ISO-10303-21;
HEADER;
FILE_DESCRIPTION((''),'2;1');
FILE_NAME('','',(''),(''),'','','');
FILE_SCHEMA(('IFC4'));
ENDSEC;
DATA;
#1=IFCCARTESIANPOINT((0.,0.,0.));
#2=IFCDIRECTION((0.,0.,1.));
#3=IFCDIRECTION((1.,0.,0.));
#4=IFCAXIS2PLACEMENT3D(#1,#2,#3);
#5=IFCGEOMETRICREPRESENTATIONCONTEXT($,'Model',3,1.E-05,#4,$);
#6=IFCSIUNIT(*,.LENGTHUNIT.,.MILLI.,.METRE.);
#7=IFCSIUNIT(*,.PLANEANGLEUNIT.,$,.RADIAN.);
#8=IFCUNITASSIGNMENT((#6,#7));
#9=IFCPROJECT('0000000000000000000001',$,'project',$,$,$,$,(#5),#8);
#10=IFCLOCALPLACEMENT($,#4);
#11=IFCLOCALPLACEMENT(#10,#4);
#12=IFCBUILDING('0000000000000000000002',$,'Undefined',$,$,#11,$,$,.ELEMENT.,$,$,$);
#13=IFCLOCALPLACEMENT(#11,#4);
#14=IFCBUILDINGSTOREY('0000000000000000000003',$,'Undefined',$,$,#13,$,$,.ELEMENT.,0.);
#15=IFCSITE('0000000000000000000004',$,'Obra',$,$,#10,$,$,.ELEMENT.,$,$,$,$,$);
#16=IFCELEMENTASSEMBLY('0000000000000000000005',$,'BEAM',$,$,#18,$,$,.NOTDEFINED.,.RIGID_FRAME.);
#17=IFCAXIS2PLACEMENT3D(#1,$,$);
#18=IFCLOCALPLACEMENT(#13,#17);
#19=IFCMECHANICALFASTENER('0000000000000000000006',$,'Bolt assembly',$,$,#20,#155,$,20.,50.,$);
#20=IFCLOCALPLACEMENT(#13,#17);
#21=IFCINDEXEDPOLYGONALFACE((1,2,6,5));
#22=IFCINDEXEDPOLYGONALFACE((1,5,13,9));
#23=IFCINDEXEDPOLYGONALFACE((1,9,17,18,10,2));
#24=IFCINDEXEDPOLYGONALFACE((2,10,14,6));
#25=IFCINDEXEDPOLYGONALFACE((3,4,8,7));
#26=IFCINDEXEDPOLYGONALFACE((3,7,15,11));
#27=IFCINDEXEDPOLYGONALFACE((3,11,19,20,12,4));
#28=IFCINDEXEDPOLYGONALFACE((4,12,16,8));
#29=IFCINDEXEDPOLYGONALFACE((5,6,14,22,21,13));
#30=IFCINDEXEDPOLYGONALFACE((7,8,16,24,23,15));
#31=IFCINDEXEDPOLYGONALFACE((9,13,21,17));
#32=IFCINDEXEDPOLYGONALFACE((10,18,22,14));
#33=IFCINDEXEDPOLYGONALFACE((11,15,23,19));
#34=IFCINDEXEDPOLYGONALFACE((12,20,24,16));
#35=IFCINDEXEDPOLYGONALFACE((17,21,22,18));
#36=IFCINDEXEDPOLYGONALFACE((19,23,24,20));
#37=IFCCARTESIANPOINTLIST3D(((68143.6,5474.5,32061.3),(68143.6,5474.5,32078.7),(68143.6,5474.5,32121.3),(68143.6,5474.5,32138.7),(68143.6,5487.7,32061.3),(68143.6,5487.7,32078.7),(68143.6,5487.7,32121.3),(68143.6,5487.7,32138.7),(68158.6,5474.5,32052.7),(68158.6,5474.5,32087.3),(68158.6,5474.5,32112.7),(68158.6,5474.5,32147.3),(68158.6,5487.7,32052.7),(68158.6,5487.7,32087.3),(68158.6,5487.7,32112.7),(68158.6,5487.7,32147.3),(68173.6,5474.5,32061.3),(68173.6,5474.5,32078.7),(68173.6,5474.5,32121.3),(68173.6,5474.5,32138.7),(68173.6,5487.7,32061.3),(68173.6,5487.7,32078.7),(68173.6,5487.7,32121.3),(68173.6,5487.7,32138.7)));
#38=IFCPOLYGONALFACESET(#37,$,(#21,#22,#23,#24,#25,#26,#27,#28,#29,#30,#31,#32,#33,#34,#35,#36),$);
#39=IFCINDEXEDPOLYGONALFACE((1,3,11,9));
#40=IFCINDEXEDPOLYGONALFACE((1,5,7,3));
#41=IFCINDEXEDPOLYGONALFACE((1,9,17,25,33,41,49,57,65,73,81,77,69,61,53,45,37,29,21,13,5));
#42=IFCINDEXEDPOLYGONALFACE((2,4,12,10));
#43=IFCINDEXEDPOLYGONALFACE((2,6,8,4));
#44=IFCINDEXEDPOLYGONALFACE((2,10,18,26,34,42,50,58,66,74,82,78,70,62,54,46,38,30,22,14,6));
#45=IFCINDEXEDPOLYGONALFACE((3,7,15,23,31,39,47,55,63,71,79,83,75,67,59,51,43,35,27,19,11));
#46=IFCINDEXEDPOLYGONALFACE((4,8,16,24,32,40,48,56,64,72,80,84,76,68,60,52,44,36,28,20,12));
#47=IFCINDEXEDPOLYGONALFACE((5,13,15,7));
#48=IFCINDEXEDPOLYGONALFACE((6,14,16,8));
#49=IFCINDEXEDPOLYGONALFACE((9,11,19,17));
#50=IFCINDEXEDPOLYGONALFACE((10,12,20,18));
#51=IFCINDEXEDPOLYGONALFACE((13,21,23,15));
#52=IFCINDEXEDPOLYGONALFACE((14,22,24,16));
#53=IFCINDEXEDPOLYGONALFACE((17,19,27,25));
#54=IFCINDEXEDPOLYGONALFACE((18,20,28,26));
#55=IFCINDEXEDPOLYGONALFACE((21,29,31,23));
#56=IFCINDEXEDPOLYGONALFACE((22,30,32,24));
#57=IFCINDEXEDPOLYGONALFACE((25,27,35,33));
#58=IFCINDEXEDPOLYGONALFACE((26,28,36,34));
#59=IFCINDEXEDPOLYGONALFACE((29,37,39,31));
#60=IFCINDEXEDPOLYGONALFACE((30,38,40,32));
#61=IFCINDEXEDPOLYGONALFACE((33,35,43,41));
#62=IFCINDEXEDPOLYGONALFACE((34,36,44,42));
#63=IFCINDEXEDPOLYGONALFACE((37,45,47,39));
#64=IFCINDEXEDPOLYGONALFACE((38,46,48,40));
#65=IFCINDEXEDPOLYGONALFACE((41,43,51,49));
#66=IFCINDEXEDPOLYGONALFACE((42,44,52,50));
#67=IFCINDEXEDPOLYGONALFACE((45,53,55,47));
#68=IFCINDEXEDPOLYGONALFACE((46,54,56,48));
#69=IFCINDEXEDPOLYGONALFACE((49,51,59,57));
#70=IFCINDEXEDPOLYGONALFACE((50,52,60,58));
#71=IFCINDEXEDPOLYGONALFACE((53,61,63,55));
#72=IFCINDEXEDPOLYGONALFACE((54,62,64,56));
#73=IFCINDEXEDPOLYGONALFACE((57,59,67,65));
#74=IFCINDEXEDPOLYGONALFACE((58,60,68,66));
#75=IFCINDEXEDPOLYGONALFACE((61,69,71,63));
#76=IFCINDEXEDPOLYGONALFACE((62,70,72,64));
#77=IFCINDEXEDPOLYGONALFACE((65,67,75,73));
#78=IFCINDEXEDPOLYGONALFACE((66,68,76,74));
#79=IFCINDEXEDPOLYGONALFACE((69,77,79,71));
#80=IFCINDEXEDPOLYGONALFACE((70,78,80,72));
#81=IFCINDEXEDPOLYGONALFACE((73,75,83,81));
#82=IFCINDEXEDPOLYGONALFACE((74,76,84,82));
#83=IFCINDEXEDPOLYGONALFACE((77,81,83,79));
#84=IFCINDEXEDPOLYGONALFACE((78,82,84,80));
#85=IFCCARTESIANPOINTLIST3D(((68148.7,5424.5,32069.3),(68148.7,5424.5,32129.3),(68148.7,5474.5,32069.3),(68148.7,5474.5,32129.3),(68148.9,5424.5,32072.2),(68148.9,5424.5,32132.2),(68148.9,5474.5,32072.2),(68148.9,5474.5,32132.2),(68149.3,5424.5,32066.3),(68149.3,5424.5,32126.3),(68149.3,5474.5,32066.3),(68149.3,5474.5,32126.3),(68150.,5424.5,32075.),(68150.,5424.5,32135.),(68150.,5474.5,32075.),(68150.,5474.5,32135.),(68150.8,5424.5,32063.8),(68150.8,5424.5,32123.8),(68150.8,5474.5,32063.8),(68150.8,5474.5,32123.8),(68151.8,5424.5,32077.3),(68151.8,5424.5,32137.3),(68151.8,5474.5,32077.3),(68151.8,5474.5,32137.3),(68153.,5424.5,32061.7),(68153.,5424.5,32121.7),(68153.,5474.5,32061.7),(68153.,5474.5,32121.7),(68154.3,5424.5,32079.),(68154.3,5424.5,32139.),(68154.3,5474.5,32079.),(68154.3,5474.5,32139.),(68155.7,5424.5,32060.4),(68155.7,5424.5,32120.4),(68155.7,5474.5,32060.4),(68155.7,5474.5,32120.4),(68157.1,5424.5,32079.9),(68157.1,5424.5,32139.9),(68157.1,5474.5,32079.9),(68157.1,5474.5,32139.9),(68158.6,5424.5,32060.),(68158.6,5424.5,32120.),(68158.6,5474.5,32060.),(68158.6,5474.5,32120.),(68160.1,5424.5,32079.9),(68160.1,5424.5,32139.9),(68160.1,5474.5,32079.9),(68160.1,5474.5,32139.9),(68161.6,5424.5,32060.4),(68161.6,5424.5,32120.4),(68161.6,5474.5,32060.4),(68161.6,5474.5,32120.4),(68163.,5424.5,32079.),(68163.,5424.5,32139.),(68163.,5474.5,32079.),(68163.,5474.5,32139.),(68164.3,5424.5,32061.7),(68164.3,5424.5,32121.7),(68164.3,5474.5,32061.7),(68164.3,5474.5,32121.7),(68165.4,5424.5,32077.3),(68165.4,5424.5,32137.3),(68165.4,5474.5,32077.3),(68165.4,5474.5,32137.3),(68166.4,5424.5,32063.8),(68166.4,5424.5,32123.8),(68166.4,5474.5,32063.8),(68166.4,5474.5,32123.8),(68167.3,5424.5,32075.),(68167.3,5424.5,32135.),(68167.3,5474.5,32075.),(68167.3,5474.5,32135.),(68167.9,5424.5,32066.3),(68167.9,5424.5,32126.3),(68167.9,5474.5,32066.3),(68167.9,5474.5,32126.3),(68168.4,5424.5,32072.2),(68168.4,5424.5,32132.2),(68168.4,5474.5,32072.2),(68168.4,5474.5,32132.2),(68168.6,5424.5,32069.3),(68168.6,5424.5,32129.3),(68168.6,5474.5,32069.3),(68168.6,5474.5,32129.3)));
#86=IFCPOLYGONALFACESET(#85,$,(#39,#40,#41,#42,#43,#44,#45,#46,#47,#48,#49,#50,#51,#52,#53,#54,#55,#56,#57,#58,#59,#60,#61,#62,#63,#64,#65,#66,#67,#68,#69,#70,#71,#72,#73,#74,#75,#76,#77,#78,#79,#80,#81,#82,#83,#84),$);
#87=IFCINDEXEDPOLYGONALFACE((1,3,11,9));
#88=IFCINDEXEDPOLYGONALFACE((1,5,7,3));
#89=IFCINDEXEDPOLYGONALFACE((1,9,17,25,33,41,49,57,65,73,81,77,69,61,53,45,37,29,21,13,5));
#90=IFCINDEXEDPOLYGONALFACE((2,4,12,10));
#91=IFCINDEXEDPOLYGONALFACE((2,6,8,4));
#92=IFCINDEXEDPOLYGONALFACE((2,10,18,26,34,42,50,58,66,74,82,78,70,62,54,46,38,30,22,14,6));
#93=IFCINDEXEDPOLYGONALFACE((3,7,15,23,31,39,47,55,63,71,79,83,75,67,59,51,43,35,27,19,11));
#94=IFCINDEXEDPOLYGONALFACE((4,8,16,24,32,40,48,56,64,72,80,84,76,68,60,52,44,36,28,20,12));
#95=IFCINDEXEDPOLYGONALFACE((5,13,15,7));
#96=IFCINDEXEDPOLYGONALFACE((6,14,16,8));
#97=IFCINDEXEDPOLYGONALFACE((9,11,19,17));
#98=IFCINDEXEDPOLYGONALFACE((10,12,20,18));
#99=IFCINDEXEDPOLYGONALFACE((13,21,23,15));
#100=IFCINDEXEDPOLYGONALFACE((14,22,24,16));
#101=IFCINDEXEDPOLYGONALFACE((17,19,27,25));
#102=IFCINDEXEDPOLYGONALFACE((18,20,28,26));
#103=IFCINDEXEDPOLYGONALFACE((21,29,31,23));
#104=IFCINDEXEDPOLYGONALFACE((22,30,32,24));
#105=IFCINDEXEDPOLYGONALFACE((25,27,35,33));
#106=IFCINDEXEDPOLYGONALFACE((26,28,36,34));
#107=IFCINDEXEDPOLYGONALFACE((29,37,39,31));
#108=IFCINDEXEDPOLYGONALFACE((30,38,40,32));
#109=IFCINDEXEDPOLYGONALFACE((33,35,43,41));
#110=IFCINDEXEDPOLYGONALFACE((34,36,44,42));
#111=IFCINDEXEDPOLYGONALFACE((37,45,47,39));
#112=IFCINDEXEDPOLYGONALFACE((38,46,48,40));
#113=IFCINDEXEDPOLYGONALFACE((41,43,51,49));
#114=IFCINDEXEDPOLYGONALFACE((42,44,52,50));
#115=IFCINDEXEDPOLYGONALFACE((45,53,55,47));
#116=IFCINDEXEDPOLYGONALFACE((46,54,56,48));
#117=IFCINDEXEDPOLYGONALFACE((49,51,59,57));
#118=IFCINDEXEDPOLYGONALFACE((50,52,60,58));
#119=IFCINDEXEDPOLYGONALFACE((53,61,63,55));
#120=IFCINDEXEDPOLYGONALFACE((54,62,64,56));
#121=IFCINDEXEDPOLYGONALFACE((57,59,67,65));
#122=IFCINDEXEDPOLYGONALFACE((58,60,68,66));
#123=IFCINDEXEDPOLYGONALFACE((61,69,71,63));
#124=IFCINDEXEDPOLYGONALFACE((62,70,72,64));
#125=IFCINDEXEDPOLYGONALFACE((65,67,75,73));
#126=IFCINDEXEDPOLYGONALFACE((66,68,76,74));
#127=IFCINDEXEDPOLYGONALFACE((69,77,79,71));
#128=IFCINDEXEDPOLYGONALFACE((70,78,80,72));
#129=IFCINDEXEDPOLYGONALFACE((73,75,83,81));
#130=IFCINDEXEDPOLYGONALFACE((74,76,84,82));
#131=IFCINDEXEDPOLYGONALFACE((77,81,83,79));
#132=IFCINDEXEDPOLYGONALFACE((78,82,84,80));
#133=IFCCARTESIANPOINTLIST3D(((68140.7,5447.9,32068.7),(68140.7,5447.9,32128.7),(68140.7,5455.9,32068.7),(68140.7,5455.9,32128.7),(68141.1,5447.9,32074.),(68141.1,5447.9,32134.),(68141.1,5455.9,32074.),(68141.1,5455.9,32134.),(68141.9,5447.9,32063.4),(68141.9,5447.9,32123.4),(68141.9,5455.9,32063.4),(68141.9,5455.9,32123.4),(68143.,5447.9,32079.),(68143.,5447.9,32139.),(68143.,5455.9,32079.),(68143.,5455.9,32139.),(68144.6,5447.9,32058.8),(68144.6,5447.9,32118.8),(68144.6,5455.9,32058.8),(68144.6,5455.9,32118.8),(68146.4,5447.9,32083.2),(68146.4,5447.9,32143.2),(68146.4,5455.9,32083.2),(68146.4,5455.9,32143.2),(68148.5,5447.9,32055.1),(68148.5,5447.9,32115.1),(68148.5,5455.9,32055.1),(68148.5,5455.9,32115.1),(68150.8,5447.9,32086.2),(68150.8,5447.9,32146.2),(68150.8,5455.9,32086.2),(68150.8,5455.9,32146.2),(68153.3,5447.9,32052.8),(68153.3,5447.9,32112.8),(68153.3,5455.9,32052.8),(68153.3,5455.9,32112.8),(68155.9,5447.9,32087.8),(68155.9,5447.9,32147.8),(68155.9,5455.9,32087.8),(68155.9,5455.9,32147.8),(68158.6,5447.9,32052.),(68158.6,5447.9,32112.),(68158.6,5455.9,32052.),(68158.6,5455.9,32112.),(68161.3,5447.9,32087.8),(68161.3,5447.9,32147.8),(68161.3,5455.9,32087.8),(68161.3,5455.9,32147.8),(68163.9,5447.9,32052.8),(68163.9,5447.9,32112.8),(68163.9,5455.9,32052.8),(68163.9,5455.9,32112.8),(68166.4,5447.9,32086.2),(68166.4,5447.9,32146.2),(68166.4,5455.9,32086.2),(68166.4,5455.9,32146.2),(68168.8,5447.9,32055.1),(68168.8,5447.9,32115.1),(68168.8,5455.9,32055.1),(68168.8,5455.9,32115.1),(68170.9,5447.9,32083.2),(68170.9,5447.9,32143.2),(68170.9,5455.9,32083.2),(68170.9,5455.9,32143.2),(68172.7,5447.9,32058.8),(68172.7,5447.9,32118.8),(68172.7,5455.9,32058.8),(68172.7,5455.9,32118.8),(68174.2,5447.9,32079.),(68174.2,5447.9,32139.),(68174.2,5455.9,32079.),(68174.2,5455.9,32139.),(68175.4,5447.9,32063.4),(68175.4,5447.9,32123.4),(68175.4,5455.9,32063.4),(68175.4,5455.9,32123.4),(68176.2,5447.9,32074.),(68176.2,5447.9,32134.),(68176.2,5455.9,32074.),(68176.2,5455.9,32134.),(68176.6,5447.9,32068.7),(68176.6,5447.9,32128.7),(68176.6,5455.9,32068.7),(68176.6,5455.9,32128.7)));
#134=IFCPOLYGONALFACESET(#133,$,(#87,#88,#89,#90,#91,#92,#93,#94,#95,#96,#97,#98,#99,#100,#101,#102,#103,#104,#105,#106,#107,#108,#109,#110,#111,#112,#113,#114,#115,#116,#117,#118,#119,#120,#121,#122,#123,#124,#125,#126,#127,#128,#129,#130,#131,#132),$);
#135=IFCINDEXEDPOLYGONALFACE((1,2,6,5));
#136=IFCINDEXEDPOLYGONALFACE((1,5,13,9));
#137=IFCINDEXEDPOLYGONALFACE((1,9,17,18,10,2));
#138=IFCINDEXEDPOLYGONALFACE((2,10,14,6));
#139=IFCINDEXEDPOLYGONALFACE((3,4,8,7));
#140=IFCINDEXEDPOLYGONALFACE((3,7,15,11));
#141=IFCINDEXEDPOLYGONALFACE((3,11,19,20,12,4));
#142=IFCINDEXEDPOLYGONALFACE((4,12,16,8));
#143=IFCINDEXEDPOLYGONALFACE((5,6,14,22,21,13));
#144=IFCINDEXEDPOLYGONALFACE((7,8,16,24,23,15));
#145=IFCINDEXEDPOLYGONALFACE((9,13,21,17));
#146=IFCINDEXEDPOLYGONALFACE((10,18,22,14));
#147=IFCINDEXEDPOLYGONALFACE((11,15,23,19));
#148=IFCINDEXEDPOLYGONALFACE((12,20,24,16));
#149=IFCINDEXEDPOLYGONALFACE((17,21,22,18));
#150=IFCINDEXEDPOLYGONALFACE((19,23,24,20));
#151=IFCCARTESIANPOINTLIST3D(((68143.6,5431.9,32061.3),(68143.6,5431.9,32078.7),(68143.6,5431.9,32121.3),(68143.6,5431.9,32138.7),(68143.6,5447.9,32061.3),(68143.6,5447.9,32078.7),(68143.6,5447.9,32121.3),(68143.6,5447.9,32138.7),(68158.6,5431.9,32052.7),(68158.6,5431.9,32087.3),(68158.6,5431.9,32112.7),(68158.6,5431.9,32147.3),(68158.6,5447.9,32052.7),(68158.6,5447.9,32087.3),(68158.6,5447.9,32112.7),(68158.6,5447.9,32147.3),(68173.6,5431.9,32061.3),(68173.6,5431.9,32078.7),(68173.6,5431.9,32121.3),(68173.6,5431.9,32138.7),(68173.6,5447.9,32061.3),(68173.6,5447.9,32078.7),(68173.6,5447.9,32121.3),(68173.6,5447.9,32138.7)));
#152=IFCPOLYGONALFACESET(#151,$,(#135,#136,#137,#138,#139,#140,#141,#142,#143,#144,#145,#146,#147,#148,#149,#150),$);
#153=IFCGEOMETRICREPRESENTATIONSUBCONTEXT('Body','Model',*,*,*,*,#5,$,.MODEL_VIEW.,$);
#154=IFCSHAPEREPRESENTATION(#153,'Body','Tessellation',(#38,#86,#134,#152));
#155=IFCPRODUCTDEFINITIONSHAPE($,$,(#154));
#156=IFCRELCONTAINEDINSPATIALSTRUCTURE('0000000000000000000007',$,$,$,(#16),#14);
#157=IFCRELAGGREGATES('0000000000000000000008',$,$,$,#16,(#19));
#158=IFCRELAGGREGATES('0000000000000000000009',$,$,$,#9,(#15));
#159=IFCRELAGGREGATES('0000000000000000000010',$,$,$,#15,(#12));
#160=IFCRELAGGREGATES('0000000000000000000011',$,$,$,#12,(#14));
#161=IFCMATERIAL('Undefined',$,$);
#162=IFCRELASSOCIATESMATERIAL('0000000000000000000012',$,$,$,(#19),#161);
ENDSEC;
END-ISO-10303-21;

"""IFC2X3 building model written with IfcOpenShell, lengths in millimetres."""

from ifc_helpers import new_model, si_unit, frame, origin_with_axes, origin_2d_with_axis, place, context, subcontext, project, spatial, polyline, circle, outline, extrude, source, transform, mapped, material, element, aggregate, save


model = new_model("IFC2X3")

# Units and contexts
model_context = context("Model", 3, precision=1e-05, world=origin_with_axes())
body_context = subcontext(model_context, "Body", "Model", "MODEL_VIEW")
ifc_project = project(units=[si_unit("LENGTHUNIT", "METRE", prefix="MILLI"), si_unit("PLANEANGLEUNIT", "RADIAN")], contexts=[model_context])

# Site, building, storey
site_placement = place(None, origin_with_axes())
site = spatial("IfcSite", under=ifc_project, at=site_placement, Name="Obra", CompositionType="ELEMENT")
building_placement = place(site_placement, origin_with_axes())
building = spatial("IfcBuilding", under=site, at=building_placement, Name="Undefined", CompositionType="ELEMENT")
storey_placement = place(building_placement, origin_with_axes())
storey = spatial("IfcBuildingStorey", under=building, at=storey_placement, Name="Undefined", CompositionType="ELEMENT", Elevation=0.0)

# Element assembly
assembly_1_placement = place(storey_placement, origin_with_axes())
assembly_1 = element("IfcElementAssembly", 1, at=assembly_1_placement, inside=storey, Name="BEAM", AssemblyPlace="NOTDEFINED", PredefinedType="RIGID_FRAME")

# Shared definitions
ifc_material_1 = material(Name="Undefined")

# Mechanical fastener
shared_shape_1 = source(origin_with_axes(), body_context, "Body", "SweptSolid", [
    extrude(outline(polyline([(17.3, 0.0), (8.7, 15.0), (-8.7, 15.0), (-17.3, 0.0), (-8.7, -15.0), (8.7, -15.0), (17.3, 0.0)])), frame((0.0, -27.5, 0.0), z_axis=(0.0, 1.0, 0.0), x_axis=(1.0, 0.0, 0.0)), (0.0, 0.0, 1.0), 13.2),
    extrude(circle(Radius=10.0, at=origin_2d_with_axis()), frame((0.0, -14.3, 0.0), z_axis=(0.0, 1.0, 0.0), x_axis=(1.0, 0.0, 0.0)), (0.0, 0.0, 1.0), 50.0),
    extrude(circle(Radius=18.0, at=origin_2d_with_axis()), frame((0.0, 4.3, 0.0), z_axis=(0.0, 1.0, 0.0), x_axis=(1.0, 0.0, 0.0)), (0.0, 0.0, 1.0), 8.0),
    extrude(outline(polyline([(17.3, 0.0), (8.7, 15.0), (-8.7, 15.0), (-17.3, 0.0), (-8.7, -15.0), (8.7, -15.0), (17.3, 0.0)])), frame((0.0, 12.3, 0.0), z_axis=(0.0, 1.0, 0.0), x_axis=(1.0, 0.0, 0.0)), (0.0, 0.0, 1.0), 16.0),
])
mechanical_fastener_1_placement = place(assembly_1_placement, frame((68198.6, 5460.2, 32170.0), z_axis=(-1.0, 0.0, 0.0), x_axis=(0.0, 0.0, -1.0)))
mechanical_fastener_1 = element("IfcMechanicalFastener", 2, at=mechanical_fastener_1_placement, material=ifc_material_1, Name="Bolt assembly", NominalDiameter=20.0, NominalLength=50.0, context=body_context, shape_type="MappedRepresentation", body=[
    mapped(shared_shape_1, transform((40.0, 0.0, 40.0))),
    mapped(shared_shape_1, transform((100.0, 0.0, 40.0))),
])
aggregate(assembly_1, [mechanical_fastener_1])

save(model, "model.ifc")
